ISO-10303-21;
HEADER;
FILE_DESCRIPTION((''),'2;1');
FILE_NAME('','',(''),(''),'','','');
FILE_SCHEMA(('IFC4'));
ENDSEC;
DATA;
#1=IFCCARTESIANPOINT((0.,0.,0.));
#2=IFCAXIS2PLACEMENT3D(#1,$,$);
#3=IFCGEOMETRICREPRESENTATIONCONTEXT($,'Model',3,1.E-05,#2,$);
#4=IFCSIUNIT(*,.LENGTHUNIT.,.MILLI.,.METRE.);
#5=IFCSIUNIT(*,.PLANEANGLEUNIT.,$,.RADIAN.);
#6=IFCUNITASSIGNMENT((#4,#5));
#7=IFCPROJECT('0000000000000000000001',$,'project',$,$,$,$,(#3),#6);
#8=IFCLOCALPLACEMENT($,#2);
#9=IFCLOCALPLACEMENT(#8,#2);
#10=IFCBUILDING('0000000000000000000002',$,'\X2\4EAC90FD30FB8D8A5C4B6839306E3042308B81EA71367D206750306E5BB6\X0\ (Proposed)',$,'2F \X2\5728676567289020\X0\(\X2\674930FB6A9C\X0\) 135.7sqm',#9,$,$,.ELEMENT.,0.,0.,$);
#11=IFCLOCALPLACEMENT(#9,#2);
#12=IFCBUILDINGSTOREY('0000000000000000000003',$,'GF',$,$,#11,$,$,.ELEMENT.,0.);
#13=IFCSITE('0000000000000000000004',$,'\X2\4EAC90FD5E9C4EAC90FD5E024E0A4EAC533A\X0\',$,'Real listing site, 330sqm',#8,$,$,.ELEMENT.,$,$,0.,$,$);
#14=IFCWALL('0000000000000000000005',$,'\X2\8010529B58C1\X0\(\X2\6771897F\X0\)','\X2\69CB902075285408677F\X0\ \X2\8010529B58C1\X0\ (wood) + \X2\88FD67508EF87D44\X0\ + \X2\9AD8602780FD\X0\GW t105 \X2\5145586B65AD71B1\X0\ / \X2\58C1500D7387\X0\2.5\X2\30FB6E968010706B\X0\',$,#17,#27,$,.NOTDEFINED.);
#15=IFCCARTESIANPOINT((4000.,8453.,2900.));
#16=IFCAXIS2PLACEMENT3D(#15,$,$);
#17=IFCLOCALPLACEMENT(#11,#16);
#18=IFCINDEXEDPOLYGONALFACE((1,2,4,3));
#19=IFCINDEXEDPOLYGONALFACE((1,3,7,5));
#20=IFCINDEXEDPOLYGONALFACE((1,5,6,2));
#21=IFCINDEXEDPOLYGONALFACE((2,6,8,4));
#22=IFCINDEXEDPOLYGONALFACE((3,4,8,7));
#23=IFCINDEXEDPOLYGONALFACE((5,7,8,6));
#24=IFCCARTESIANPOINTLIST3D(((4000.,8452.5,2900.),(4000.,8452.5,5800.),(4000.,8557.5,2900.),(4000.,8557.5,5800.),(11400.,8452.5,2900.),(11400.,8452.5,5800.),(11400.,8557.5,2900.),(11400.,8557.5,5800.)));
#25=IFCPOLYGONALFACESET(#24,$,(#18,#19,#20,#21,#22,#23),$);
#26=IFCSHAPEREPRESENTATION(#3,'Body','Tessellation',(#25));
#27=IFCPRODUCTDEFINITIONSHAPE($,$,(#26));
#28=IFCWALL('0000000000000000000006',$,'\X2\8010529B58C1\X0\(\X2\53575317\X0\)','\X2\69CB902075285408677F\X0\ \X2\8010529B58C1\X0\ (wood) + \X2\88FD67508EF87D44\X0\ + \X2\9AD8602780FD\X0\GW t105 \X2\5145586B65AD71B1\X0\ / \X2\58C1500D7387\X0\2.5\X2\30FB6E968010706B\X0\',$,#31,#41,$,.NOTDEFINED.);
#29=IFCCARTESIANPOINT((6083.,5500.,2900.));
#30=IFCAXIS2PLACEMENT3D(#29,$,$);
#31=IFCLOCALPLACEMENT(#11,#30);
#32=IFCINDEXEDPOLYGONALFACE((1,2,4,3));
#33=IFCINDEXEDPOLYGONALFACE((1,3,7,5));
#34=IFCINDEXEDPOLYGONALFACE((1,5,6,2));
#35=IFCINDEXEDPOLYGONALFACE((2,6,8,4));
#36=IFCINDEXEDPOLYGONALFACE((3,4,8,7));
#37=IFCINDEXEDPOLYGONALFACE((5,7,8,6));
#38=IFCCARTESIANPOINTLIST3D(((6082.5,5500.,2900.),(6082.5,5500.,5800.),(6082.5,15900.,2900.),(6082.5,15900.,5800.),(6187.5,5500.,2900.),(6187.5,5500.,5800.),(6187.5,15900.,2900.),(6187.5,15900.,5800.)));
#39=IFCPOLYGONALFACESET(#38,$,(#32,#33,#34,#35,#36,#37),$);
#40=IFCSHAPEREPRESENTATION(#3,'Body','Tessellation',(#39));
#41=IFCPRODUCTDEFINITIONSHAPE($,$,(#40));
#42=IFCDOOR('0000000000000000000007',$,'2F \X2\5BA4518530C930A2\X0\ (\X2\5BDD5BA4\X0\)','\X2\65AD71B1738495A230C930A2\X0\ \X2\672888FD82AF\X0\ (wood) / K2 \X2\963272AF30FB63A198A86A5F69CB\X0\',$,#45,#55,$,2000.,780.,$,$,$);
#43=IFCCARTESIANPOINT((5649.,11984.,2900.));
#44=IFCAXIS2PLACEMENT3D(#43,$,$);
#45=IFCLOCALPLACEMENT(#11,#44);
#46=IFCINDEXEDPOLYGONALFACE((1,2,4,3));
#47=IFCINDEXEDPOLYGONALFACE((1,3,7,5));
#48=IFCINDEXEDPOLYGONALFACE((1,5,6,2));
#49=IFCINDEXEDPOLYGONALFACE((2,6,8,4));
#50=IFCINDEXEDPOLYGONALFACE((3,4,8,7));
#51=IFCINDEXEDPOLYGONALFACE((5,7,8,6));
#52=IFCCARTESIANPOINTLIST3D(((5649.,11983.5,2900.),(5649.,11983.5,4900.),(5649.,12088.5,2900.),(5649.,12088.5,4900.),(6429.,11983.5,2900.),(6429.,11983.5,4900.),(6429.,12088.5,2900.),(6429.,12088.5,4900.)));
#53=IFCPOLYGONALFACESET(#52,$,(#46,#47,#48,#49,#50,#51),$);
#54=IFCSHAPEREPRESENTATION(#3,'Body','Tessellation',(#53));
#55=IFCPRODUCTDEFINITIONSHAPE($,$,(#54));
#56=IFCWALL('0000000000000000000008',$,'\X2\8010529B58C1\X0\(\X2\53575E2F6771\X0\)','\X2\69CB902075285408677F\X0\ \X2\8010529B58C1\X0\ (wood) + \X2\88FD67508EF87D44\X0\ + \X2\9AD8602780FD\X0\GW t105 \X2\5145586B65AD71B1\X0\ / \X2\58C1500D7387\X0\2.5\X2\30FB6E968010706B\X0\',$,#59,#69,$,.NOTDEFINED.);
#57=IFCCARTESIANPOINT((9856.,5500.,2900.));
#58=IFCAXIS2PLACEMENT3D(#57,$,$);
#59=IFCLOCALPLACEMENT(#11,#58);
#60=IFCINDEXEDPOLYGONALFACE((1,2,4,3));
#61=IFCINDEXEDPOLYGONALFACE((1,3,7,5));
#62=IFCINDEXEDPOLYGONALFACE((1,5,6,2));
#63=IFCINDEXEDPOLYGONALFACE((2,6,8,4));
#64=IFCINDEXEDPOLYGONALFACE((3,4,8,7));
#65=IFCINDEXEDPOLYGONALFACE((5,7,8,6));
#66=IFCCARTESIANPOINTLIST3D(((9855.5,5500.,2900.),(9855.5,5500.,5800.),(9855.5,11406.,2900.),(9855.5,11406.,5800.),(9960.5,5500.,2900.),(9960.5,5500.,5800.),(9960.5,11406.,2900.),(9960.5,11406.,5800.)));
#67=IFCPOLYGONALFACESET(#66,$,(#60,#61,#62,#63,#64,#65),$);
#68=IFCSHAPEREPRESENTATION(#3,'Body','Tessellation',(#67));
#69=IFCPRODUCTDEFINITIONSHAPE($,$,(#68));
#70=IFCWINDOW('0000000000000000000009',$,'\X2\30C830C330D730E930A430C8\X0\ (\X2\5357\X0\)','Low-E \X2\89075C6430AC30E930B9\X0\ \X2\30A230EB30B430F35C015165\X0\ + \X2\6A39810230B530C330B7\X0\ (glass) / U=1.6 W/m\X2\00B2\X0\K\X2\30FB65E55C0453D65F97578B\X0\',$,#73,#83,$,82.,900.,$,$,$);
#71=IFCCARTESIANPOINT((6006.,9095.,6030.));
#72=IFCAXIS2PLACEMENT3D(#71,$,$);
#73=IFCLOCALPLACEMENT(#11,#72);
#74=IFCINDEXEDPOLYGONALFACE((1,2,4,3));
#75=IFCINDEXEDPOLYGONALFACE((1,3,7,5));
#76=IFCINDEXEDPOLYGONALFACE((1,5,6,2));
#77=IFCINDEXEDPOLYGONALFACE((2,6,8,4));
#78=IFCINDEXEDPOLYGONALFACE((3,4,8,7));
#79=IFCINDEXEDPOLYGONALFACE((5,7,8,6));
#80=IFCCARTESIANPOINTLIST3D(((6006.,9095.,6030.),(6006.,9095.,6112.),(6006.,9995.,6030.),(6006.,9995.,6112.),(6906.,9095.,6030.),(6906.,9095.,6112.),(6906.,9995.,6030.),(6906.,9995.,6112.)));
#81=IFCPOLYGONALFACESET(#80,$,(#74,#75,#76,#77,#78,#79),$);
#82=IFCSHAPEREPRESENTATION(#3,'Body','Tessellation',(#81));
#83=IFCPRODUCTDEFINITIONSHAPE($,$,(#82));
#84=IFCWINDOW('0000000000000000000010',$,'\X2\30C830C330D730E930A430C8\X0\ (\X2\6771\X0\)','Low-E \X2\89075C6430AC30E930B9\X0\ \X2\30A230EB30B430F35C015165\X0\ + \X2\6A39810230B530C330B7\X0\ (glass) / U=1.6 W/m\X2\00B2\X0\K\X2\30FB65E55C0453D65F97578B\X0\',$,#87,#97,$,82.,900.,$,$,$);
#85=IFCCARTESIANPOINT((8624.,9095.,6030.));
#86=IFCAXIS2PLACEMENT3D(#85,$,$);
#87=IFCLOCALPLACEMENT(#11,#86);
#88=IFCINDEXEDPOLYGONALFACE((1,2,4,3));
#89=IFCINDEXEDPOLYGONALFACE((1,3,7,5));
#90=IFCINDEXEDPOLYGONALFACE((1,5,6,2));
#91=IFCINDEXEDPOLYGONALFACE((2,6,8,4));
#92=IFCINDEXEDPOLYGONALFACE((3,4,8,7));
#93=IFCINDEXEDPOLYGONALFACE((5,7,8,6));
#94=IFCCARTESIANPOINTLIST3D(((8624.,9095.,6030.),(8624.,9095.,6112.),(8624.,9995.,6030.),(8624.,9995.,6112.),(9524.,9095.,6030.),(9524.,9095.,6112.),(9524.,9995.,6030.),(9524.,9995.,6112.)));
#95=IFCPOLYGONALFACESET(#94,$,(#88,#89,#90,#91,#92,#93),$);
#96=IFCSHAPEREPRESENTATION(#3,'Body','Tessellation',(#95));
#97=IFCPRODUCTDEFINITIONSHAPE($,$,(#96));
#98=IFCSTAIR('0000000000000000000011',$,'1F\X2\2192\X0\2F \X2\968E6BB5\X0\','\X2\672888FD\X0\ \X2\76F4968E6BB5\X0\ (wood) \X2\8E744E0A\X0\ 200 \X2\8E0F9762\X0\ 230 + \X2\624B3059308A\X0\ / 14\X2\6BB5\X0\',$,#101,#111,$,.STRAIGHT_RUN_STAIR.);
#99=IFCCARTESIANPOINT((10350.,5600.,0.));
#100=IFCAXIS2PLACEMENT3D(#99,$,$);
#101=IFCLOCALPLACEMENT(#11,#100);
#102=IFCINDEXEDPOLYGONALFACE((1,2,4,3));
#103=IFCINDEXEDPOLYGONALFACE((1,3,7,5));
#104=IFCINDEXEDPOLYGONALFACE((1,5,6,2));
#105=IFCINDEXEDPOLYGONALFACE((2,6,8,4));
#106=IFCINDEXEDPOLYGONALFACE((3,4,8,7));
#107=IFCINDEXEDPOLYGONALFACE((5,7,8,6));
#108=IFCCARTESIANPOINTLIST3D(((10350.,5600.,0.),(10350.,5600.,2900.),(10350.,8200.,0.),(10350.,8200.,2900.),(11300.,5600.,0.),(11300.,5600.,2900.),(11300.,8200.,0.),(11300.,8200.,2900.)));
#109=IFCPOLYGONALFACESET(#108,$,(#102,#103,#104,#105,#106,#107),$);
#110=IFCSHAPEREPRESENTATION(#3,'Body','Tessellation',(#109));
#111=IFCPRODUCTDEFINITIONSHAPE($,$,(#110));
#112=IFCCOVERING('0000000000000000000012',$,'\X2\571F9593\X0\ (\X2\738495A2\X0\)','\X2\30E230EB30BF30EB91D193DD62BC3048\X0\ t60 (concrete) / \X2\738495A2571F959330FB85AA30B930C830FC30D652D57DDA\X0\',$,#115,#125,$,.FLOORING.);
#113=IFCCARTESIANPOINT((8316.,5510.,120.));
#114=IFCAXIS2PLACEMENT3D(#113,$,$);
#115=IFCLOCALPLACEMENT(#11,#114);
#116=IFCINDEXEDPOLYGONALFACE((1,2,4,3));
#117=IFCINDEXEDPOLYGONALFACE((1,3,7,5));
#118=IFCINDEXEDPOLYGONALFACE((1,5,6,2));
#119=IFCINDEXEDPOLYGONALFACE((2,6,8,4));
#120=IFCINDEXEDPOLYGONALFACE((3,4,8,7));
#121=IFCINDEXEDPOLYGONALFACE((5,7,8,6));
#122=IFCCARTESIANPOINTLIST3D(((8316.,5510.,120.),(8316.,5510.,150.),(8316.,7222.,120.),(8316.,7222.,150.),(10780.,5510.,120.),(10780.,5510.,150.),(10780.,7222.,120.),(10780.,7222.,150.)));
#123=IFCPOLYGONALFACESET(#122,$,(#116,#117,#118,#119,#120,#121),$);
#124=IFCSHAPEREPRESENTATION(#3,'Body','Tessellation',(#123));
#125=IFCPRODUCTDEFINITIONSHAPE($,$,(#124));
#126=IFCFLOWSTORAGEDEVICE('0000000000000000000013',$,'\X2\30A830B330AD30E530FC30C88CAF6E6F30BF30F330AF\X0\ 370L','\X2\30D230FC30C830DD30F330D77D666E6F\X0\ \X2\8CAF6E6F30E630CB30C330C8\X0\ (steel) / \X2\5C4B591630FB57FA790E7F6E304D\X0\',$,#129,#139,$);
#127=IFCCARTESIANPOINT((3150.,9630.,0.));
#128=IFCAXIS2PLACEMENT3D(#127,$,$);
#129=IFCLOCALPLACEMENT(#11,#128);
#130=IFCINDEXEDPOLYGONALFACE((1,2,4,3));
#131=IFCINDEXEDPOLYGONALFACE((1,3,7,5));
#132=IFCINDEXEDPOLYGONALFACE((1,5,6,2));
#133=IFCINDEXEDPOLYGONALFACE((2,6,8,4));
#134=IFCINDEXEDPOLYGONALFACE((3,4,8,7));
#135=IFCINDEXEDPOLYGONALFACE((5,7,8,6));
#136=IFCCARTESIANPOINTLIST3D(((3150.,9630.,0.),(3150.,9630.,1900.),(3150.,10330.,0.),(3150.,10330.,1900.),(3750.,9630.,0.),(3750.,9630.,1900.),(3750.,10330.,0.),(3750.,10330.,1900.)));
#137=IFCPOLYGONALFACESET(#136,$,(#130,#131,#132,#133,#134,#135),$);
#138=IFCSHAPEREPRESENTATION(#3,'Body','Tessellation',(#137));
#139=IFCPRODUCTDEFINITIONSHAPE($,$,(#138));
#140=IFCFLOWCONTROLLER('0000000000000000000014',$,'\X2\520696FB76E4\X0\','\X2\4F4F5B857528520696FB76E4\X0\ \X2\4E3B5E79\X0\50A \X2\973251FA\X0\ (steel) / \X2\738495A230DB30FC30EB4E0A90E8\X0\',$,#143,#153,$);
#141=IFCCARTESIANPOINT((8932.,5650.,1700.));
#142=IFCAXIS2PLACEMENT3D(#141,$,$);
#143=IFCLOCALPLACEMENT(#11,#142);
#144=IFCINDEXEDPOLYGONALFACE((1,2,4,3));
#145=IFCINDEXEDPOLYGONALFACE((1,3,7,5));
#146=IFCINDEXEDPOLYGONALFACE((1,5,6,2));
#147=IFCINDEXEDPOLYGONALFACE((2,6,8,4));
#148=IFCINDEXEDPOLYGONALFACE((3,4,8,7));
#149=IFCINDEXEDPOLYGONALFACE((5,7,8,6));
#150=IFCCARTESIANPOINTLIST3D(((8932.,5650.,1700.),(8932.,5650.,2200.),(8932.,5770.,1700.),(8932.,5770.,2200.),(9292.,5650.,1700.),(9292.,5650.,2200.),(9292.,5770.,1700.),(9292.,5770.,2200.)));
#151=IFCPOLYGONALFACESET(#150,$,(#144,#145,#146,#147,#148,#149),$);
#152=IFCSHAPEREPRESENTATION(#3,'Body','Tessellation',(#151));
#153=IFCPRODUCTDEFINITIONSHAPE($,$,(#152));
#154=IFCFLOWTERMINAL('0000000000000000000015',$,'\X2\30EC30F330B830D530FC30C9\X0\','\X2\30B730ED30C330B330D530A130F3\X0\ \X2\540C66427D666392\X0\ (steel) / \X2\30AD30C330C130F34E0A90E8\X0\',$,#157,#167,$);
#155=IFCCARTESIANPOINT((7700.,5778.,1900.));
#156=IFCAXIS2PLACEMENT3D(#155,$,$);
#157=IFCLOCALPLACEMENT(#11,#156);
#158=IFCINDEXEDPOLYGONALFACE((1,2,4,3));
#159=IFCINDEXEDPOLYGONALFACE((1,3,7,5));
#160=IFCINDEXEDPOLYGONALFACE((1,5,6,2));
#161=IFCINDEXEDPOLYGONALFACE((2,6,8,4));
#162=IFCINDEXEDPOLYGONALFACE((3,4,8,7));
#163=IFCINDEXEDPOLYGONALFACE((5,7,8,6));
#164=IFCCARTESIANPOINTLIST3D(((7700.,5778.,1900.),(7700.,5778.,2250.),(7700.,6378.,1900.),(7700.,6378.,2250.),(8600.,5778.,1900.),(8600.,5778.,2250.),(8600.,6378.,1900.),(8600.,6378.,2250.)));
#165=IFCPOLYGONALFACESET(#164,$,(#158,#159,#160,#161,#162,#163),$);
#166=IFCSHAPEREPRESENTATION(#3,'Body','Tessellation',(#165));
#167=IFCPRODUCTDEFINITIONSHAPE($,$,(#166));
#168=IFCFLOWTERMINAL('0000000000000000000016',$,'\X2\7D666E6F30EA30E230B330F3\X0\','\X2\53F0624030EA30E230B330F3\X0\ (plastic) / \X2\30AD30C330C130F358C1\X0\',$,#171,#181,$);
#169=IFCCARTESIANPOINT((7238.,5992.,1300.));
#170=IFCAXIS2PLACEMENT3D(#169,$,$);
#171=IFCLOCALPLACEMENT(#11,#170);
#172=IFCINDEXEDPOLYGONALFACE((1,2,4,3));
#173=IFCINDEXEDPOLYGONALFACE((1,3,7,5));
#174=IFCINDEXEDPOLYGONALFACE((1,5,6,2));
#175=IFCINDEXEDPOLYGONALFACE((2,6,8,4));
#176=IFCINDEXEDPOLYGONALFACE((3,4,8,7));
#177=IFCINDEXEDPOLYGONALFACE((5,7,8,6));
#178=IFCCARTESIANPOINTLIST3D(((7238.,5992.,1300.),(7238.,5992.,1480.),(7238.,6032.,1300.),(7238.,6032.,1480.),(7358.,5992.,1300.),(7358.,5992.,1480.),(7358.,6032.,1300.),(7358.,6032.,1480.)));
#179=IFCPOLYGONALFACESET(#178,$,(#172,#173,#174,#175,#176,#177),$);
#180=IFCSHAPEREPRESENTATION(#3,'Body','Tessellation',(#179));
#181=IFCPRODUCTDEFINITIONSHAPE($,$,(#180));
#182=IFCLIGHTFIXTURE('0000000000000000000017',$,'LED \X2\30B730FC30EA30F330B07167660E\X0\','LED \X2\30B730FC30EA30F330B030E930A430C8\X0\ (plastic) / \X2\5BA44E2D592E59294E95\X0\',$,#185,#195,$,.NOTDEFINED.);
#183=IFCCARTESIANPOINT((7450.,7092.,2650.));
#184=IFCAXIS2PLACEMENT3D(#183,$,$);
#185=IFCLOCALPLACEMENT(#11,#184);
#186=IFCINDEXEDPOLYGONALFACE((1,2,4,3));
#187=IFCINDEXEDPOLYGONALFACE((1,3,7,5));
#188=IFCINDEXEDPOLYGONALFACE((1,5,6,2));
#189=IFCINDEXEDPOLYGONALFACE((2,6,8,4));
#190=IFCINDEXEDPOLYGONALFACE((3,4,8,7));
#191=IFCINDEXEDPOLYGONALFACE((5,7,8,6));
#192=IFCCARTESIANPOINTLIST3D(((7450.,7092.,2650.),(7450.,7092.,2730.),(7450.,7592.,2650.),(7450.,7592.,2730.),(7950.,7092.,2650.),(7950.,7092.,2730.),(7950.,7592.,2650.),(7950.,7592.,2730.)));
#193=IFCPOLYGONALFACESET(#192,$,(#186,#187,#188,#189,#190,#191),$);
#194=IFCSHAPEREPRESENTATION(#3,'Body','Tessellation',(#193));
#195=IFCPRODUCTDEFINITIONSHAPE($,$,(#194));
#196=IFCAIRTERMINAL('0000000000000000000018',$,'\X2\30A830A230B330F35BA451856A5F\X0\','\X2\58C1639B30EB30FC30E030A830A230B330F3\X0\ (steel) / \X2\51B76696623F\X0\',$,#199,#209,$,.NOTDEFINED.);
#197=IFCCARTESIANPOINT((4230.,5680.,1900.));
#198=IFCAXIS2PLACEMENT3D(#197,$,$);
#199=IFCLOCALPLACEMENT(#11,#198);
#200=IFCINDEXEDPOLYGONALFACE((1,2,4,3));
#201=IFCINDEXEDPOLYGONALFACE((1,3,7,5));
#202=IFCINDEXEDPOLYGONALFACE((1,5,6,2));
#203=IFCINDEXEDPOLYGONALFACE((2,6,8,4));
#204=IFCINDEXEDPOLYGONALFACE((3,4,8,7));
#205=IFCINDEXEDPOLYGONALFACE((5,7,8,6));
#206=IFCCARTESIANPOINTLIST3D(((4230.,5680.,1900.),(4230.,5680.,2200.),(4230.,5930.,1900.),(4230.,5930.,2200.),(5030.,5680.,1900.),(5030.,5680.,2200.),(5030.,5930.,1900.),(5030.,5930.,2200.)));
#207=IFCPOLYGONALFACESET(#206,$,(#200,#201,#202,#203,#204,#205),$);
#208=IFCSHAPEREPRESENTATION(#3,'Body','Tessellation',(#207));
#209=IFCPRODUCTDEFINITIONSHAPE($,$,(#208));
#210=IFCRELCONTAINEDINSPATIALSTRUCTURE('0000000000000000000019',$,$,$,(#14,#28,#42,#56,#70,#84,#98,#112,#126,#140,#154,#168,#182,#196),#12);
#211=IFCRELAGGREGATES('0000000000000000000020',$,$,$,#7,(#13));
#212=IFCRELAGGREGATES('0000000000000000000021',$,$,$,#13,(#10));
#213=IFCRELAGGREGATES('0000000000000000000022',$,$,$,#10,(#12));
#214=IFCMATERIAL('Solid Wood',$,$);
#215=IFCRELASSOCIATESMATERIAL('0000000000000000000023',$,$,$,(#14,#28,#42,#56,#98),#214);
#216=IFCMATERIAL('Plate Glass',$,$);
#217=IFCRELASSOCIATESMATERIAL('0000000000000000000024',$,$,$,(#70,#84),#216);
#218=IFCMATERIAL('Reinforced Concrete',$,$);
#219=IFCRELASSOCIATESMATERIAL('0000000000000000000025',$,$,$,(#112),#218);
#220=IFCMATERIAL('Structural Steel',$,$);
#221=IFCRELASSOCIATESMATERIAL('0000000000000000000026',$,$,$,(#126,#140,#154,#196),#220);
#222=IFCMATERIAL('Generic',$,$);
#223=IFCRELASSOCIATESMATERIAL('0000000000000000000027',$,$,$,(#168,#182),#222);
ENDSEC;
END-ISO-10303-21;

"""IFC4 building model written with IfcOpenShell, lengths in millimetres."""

from ifc_helpers import new_model, si_unit, frame, frame_2d, origin, place, context, project, spatial, rectangle, extrude, material, element, fill, save


model = new_model("IFC4")

# Units and contexts
model_context = context("Model", 3, precision=1e-05, world=origin())
ifc_project = project(units=[si_unit("LENGTHUNIT", "METRE", prefix="MILLI"), si_unit("PLANEANGLEUNIT", "RADIAN")], contexts=[model_context])

# Site, building, storey
site_placement = place(None, origin())
site = spatial("IfcSite", under=ifc_project, at=site_placement, Name="京都府京都市上京区", ObjectType="Real listing site, 330sqm", CompositionType="ELEMENT", RefElevation=0.0)
building_placement = place(site_placement, origin())
building = spatial("IfcBuilding", under=site, at=building_placement, Name="京都・越屋根のある自然素材の家 (Proposed)", ObjectType="2F 在来木造(杉・檜) 135.7sqm", CompositionType="ELEMENT", ElevationOfRefHeight=0.0, ElevationOfTerrain=0.0)
storey_placement = place(building_placement, origin())
storey = spatial("IfcBuildingStorey", under=building, at=storey_placement, Name="GF", CompositionType="ELEMENT", Elevation=0.0)

# Shared definitions
ifc_material_1 = material(Name="Solid Wood")

# Wall
wall_1_placement = place(storey_placement, frame((4000.0, 8453.0, 2900.0)))
element("IfcWall", 1, at=wall_1_placement, inside=storey, material=ifc_material_1, Name="耐力壁(東西)", Description="構造用合板 耐力壁 (wood) + 製材軸組 + 高性能GW t105 充填断熱 / 壁倍率2.5・準耐火", PredefinedType="NOTDEFINED", context=model_context, shape_type="SweptSolid", body=[
    extrude(rectangle(XDim=7400.0, YDim=105.0, at=frame_2d((3700.0, 52.0))), frame((4000.0, 8453.0, 2900.0)), (0.0, 0.0, 1.0), 2900.0),
])

# Wall, opening, door
wall_2_placement = place(storey_placement, frame((6083.0, 5500.0, 2900.0)))
wall_2 = element("IfcWall", 2, at=wall_2_placement, inside=storey, material=ifc_material_1, Name="耐力壁(南北)", Description="構造用合板 耐力壁 (wood) + 製材軸組 + 高性能GW t105 充填断熱 / 壁倍率2.5・準耐火", PredefinedType="NOTDEFINED", context=model_context, shape_type="SweptSolid", body=[
    extrude(rectangle(XDim=105.0, YDim=10400.0, at=frame_2d((52.0, 5200.0))), frame((6083.0, 5500.0, 2900.0)), (0.0, 0.0, 1.0), 2900.0),
])
opening_placement = place(storey_placement, frame((5649.0, 11984.0, 2900.0)))
opening = element("IfcOpeningElement", 3, at=opening_placement, cuts=wall_2, PredefinedType="NOTDEFINED", context=model_context, shape_type="SweptSolid", body=[
    extrude(rectangle(XDim=780.0, YDim=105.0, at=frame_2d((390.0, 52.0))), frame((5649.0, 11984.0, 2900.0)), (0.0, 0.0, 1.0), 2000.0),
])
door_placement = place(storey_placement, frame((5649.0, 11984.0, 2900.0)))
door = element("IfcDoor", 4, at=door_placement, inside=storey, material=ifc_material_1, Name="2F 室内ドア (寝室)", Description="断熱玄関ドア 木製芯 (wood) / K2 防犯・採風機構", OverallHeight=2000.0, OverallWidth=780.0, context=model_context, shape_type="SweptSolid", body=[
    extrude(rectangle(XDim=780.0, YDim=105.0, at=frame_2d((390.0, 52.0))), frame((5649.0, 11984.0, 2900.0)), (0.0, 0.0, 1.0), 2000.0),
])
fill(opening, door)

# Wall
wall_3_placement = place(storey_placement, frame((9856.0, 5500.0, 2900.0)))
element("IfcWall", 5, at=wall_3_placement, inside=storey, material=ifc_material_1, Name="耐力壁(南帯東)", Description="構造用合板 耐力壁 (wood) + 製材軸組 + 高性能GW t105 充填断熱 / 壁倍率2.5・準耐火", PredefinedType="NOTDEFINED", context=model_context, shape_type="SweptSolid", body=[
    extrude(rectangle(XDim=105.0, YDim=5906.0, at=frame_2d((52.0, 2953.0))), frame((9856.0, 5500.0, 2900.0)), (0.0, 0.0, 1.0), 2900.0),
])

# Windows
ifc_material_2 = material(Name="Plate Glass")
window_1_placement = place(storey_placement, frame((6006.0, 9095.0, 6030.0)))
element("IfcWindow", 6, at=window_1_placement, inside=storey, material=ifc_material_2, Name="トップライト (南)", Description="Low-E 複層ガラス アルゴン封入 + 樹脂サッシ (glass) / U=1.6 W/m²K・日射取得型", OverallHeight=82.0, OverallWidth=900.0, context=model_context, shape_type="SweptSolid", body=[
    extrude(rectangle(XDim=900.0, YDim=900.0, at=frame_2d((450.0, 450.0))), frame((6006.0, 9095.0, 6030.0)), (0.0, 0.0, 1.0), 82.0),
])
window_2_placement = place(storey_placement, frame((8624.0, 9095.0, 6030.0)))
element("IfcWindow", 7, at=window_2_placement, inside=storey, material=ifc_material_2, Name="トップライト (東)", Description="Low-E 複層ガラス アルゴン封入 + 樹脂サッシ (glass) / U=1.6 W/m²K・日射取得型", OverallHeight=82.0, OverallWidth=900.0, context=model_context, shape_type="SweptSolid", body=[
    extrude(rectangle(XDim=900.0, YDim=900.0, at=frame_2d((450.0, 450.0))), frame((8624.0, 9095.0, 6030.0)), (0.0, 0.0, 1.0), 82.0),
])

# Stair
stair_placement = place(storey_placement, frame((10350.0, 5600.0, 0.0)))
element("IfcStair", 8, at=stair_placement, inside=storey, material=ifc_material_1, Name="1F→2F 階段", Description="木製 直階段 (wood) 蹴上 200 踏面 230 + 手すり / 14段", PredefinedType="STRAIGHT_RUN_STAIR", context=model_context, shape_type="SweptSolid", body=[
    extrude(rectangle(XDim=950.0, YDim=2600.0, at=frame_2d((475.0, 1300.0))), frame((10350.0, 5600.0, 0.0)), (0.0, 0.0, 1.0), 2900.0),
])

# Covering
ifc_material_3 = material(Name="Reinforced Concrete")
covering_placement = place(storey_placement, frame((8316.0, 5510.0, 120.0)))
element("IfcCovering", 9, at=covering_placement, inside=storey, material=ifc_material_3, Name="土間 (玄関)", Description="モルタル金鏝押え t60 (concrete) / 玄関土間・薪ストーブ動線", PredefinedType="FLOORING", context=model_context, shape_type="SweptSolid", body=[
    extrude(rectangle(XDim=2464.0, YDim=1712.0, at=frame_2d((1232.0, 856.0))), frame((8316.0, 5510.0, 120.0)), (0.0, 0.0, 1.0), 30.0),
])

# Flow storage device
ifc_material_4 = material(Name="Structural Steel")
flow_storage_device_placement = place(storey_placement, frame((3150.0, 9630.0, 0.0)))
element("IfcFlowStorageDevice", 10, at=flow_storage_device_placement, inside=storey, material=ifc_material_4, Name="エコキュート貯湯タンク 370L", Description="ヒートポンプ給湯 貯湯ユニット (steel) / 屋外・基礎置き", context=model_context, shape_type="SweptSolid", body=[
    extrude(rectangle(XDim=600.0, YDim=700.0, at=frame_2d((300.0, 350.0))), frame((3150.0, 9630.0, 0.0)), (0.0, 0.0, 1.0), 1900.0),
])

# Flow controller
flow_controller_placement = place(storey_placement, frame((8932.0, 5650.0, 1700.0)))
element("IfcFlowController", 11, at=flow_controller_placement, inside=storey, material=ifc_material_4, Name="分電盤", Description="住宅用分電盤 主幹50A 露出 (steel) / 玄関ホール上部", context=model_context, shape_type="SweptSolid", body=[
    extrude(rectangle(XDim=360.0, YDim=120.0, at=frame_2d((180.0, 60.0))), frame((8932.0, 5650.0, 1700.0)), (0.0, 0.0, 1.0), 500.0),
])

# Flow terminals
flow_terminal_1_placement = place(storey_placement, frame((7700.0, 5778.0, 1900.0)))
element("IfcFlowTerminal", 12, at=flow_terminal_1_placement, inside=storey, material=ifc_material_4, Name="レンジフード", Description="シロッコファン 同時給排 (steel) / キッチン上部", context=model_context, shape_type="SweptSolid", body=[
    extrude(rectangle(XDim=900.0, YDim=600.0, at=frame_2d((450.0, 300.0))), frame((7700.0, 5778.0, 1900.0)), (0.0, 0.0, 1.0), 350.0),
])
ifc_material_5 = material(Name="Generic")
flow_terminal_2_placement = place(storey_placement, frame((7238.0, 5992.0, 1300.0)))
element("IfcFlowTerminal", 13, at=flow_terminal_2_placement, inside=storey, material=ifc_material_5, Name="給湯リモコン", Description="台所リモコン (plastic) / キッチン壁", context=model_context, shape_type="SweptSolid", body=[
    extrude(rectangle(XDim=120.0, YDim=40.0, at=frame_2d((60.0, 20.0))), frame((7238.0, 5992.0, 1300.0)), (0.0, 0.0, 1.0), 180.0),
])

# Light fixture
light_fixture_1_placement = place(storey_placement, frame((7450.0, 7092.0, 2650.0)))
element("IfcLightFixture", 14, at=light_fixture_1_placement, inside=storey, material=ifc_material_5, Name="LED シーリング照明", Description="LED シーリングライト (plastic) / 室中央天井", PredefinedType="NOTDEFINED", context=model_context, shape_type="SweptSolid", body=[
    extrude(rectangle(XDim=500.0, YDim=500.0, at=frame_2d((250.0, 250.0))), frame((7450.0, 7092.0, 2650.0)), (0.0, 0.0, 1.0), 80.0),
])

# Air terminal
air_terminal_1_placement = place(storey_placement, frame((4230.0, 5680.0, 1900.0)))
element("IfcAirTerminal", 15, at=air_terminal_1_placement, inside=storey, material=ifc_material_4, Name="エアコン室内機", Description="壁掛ルームエアコン (steel) / 冷暖房", PredefinedType="NOTDEFINED", context=model_context, shape_type="SweptSolid", body=[
    extrude(rectangle(XDim=800.0, YDim=250.0, at=frame_2d((400.0, 125.0))), frame((4230.0, 5680.0, 1900.0)), (0.0, 0.0, 1.0), 300.0),
])

save(model, "model.ifc")
